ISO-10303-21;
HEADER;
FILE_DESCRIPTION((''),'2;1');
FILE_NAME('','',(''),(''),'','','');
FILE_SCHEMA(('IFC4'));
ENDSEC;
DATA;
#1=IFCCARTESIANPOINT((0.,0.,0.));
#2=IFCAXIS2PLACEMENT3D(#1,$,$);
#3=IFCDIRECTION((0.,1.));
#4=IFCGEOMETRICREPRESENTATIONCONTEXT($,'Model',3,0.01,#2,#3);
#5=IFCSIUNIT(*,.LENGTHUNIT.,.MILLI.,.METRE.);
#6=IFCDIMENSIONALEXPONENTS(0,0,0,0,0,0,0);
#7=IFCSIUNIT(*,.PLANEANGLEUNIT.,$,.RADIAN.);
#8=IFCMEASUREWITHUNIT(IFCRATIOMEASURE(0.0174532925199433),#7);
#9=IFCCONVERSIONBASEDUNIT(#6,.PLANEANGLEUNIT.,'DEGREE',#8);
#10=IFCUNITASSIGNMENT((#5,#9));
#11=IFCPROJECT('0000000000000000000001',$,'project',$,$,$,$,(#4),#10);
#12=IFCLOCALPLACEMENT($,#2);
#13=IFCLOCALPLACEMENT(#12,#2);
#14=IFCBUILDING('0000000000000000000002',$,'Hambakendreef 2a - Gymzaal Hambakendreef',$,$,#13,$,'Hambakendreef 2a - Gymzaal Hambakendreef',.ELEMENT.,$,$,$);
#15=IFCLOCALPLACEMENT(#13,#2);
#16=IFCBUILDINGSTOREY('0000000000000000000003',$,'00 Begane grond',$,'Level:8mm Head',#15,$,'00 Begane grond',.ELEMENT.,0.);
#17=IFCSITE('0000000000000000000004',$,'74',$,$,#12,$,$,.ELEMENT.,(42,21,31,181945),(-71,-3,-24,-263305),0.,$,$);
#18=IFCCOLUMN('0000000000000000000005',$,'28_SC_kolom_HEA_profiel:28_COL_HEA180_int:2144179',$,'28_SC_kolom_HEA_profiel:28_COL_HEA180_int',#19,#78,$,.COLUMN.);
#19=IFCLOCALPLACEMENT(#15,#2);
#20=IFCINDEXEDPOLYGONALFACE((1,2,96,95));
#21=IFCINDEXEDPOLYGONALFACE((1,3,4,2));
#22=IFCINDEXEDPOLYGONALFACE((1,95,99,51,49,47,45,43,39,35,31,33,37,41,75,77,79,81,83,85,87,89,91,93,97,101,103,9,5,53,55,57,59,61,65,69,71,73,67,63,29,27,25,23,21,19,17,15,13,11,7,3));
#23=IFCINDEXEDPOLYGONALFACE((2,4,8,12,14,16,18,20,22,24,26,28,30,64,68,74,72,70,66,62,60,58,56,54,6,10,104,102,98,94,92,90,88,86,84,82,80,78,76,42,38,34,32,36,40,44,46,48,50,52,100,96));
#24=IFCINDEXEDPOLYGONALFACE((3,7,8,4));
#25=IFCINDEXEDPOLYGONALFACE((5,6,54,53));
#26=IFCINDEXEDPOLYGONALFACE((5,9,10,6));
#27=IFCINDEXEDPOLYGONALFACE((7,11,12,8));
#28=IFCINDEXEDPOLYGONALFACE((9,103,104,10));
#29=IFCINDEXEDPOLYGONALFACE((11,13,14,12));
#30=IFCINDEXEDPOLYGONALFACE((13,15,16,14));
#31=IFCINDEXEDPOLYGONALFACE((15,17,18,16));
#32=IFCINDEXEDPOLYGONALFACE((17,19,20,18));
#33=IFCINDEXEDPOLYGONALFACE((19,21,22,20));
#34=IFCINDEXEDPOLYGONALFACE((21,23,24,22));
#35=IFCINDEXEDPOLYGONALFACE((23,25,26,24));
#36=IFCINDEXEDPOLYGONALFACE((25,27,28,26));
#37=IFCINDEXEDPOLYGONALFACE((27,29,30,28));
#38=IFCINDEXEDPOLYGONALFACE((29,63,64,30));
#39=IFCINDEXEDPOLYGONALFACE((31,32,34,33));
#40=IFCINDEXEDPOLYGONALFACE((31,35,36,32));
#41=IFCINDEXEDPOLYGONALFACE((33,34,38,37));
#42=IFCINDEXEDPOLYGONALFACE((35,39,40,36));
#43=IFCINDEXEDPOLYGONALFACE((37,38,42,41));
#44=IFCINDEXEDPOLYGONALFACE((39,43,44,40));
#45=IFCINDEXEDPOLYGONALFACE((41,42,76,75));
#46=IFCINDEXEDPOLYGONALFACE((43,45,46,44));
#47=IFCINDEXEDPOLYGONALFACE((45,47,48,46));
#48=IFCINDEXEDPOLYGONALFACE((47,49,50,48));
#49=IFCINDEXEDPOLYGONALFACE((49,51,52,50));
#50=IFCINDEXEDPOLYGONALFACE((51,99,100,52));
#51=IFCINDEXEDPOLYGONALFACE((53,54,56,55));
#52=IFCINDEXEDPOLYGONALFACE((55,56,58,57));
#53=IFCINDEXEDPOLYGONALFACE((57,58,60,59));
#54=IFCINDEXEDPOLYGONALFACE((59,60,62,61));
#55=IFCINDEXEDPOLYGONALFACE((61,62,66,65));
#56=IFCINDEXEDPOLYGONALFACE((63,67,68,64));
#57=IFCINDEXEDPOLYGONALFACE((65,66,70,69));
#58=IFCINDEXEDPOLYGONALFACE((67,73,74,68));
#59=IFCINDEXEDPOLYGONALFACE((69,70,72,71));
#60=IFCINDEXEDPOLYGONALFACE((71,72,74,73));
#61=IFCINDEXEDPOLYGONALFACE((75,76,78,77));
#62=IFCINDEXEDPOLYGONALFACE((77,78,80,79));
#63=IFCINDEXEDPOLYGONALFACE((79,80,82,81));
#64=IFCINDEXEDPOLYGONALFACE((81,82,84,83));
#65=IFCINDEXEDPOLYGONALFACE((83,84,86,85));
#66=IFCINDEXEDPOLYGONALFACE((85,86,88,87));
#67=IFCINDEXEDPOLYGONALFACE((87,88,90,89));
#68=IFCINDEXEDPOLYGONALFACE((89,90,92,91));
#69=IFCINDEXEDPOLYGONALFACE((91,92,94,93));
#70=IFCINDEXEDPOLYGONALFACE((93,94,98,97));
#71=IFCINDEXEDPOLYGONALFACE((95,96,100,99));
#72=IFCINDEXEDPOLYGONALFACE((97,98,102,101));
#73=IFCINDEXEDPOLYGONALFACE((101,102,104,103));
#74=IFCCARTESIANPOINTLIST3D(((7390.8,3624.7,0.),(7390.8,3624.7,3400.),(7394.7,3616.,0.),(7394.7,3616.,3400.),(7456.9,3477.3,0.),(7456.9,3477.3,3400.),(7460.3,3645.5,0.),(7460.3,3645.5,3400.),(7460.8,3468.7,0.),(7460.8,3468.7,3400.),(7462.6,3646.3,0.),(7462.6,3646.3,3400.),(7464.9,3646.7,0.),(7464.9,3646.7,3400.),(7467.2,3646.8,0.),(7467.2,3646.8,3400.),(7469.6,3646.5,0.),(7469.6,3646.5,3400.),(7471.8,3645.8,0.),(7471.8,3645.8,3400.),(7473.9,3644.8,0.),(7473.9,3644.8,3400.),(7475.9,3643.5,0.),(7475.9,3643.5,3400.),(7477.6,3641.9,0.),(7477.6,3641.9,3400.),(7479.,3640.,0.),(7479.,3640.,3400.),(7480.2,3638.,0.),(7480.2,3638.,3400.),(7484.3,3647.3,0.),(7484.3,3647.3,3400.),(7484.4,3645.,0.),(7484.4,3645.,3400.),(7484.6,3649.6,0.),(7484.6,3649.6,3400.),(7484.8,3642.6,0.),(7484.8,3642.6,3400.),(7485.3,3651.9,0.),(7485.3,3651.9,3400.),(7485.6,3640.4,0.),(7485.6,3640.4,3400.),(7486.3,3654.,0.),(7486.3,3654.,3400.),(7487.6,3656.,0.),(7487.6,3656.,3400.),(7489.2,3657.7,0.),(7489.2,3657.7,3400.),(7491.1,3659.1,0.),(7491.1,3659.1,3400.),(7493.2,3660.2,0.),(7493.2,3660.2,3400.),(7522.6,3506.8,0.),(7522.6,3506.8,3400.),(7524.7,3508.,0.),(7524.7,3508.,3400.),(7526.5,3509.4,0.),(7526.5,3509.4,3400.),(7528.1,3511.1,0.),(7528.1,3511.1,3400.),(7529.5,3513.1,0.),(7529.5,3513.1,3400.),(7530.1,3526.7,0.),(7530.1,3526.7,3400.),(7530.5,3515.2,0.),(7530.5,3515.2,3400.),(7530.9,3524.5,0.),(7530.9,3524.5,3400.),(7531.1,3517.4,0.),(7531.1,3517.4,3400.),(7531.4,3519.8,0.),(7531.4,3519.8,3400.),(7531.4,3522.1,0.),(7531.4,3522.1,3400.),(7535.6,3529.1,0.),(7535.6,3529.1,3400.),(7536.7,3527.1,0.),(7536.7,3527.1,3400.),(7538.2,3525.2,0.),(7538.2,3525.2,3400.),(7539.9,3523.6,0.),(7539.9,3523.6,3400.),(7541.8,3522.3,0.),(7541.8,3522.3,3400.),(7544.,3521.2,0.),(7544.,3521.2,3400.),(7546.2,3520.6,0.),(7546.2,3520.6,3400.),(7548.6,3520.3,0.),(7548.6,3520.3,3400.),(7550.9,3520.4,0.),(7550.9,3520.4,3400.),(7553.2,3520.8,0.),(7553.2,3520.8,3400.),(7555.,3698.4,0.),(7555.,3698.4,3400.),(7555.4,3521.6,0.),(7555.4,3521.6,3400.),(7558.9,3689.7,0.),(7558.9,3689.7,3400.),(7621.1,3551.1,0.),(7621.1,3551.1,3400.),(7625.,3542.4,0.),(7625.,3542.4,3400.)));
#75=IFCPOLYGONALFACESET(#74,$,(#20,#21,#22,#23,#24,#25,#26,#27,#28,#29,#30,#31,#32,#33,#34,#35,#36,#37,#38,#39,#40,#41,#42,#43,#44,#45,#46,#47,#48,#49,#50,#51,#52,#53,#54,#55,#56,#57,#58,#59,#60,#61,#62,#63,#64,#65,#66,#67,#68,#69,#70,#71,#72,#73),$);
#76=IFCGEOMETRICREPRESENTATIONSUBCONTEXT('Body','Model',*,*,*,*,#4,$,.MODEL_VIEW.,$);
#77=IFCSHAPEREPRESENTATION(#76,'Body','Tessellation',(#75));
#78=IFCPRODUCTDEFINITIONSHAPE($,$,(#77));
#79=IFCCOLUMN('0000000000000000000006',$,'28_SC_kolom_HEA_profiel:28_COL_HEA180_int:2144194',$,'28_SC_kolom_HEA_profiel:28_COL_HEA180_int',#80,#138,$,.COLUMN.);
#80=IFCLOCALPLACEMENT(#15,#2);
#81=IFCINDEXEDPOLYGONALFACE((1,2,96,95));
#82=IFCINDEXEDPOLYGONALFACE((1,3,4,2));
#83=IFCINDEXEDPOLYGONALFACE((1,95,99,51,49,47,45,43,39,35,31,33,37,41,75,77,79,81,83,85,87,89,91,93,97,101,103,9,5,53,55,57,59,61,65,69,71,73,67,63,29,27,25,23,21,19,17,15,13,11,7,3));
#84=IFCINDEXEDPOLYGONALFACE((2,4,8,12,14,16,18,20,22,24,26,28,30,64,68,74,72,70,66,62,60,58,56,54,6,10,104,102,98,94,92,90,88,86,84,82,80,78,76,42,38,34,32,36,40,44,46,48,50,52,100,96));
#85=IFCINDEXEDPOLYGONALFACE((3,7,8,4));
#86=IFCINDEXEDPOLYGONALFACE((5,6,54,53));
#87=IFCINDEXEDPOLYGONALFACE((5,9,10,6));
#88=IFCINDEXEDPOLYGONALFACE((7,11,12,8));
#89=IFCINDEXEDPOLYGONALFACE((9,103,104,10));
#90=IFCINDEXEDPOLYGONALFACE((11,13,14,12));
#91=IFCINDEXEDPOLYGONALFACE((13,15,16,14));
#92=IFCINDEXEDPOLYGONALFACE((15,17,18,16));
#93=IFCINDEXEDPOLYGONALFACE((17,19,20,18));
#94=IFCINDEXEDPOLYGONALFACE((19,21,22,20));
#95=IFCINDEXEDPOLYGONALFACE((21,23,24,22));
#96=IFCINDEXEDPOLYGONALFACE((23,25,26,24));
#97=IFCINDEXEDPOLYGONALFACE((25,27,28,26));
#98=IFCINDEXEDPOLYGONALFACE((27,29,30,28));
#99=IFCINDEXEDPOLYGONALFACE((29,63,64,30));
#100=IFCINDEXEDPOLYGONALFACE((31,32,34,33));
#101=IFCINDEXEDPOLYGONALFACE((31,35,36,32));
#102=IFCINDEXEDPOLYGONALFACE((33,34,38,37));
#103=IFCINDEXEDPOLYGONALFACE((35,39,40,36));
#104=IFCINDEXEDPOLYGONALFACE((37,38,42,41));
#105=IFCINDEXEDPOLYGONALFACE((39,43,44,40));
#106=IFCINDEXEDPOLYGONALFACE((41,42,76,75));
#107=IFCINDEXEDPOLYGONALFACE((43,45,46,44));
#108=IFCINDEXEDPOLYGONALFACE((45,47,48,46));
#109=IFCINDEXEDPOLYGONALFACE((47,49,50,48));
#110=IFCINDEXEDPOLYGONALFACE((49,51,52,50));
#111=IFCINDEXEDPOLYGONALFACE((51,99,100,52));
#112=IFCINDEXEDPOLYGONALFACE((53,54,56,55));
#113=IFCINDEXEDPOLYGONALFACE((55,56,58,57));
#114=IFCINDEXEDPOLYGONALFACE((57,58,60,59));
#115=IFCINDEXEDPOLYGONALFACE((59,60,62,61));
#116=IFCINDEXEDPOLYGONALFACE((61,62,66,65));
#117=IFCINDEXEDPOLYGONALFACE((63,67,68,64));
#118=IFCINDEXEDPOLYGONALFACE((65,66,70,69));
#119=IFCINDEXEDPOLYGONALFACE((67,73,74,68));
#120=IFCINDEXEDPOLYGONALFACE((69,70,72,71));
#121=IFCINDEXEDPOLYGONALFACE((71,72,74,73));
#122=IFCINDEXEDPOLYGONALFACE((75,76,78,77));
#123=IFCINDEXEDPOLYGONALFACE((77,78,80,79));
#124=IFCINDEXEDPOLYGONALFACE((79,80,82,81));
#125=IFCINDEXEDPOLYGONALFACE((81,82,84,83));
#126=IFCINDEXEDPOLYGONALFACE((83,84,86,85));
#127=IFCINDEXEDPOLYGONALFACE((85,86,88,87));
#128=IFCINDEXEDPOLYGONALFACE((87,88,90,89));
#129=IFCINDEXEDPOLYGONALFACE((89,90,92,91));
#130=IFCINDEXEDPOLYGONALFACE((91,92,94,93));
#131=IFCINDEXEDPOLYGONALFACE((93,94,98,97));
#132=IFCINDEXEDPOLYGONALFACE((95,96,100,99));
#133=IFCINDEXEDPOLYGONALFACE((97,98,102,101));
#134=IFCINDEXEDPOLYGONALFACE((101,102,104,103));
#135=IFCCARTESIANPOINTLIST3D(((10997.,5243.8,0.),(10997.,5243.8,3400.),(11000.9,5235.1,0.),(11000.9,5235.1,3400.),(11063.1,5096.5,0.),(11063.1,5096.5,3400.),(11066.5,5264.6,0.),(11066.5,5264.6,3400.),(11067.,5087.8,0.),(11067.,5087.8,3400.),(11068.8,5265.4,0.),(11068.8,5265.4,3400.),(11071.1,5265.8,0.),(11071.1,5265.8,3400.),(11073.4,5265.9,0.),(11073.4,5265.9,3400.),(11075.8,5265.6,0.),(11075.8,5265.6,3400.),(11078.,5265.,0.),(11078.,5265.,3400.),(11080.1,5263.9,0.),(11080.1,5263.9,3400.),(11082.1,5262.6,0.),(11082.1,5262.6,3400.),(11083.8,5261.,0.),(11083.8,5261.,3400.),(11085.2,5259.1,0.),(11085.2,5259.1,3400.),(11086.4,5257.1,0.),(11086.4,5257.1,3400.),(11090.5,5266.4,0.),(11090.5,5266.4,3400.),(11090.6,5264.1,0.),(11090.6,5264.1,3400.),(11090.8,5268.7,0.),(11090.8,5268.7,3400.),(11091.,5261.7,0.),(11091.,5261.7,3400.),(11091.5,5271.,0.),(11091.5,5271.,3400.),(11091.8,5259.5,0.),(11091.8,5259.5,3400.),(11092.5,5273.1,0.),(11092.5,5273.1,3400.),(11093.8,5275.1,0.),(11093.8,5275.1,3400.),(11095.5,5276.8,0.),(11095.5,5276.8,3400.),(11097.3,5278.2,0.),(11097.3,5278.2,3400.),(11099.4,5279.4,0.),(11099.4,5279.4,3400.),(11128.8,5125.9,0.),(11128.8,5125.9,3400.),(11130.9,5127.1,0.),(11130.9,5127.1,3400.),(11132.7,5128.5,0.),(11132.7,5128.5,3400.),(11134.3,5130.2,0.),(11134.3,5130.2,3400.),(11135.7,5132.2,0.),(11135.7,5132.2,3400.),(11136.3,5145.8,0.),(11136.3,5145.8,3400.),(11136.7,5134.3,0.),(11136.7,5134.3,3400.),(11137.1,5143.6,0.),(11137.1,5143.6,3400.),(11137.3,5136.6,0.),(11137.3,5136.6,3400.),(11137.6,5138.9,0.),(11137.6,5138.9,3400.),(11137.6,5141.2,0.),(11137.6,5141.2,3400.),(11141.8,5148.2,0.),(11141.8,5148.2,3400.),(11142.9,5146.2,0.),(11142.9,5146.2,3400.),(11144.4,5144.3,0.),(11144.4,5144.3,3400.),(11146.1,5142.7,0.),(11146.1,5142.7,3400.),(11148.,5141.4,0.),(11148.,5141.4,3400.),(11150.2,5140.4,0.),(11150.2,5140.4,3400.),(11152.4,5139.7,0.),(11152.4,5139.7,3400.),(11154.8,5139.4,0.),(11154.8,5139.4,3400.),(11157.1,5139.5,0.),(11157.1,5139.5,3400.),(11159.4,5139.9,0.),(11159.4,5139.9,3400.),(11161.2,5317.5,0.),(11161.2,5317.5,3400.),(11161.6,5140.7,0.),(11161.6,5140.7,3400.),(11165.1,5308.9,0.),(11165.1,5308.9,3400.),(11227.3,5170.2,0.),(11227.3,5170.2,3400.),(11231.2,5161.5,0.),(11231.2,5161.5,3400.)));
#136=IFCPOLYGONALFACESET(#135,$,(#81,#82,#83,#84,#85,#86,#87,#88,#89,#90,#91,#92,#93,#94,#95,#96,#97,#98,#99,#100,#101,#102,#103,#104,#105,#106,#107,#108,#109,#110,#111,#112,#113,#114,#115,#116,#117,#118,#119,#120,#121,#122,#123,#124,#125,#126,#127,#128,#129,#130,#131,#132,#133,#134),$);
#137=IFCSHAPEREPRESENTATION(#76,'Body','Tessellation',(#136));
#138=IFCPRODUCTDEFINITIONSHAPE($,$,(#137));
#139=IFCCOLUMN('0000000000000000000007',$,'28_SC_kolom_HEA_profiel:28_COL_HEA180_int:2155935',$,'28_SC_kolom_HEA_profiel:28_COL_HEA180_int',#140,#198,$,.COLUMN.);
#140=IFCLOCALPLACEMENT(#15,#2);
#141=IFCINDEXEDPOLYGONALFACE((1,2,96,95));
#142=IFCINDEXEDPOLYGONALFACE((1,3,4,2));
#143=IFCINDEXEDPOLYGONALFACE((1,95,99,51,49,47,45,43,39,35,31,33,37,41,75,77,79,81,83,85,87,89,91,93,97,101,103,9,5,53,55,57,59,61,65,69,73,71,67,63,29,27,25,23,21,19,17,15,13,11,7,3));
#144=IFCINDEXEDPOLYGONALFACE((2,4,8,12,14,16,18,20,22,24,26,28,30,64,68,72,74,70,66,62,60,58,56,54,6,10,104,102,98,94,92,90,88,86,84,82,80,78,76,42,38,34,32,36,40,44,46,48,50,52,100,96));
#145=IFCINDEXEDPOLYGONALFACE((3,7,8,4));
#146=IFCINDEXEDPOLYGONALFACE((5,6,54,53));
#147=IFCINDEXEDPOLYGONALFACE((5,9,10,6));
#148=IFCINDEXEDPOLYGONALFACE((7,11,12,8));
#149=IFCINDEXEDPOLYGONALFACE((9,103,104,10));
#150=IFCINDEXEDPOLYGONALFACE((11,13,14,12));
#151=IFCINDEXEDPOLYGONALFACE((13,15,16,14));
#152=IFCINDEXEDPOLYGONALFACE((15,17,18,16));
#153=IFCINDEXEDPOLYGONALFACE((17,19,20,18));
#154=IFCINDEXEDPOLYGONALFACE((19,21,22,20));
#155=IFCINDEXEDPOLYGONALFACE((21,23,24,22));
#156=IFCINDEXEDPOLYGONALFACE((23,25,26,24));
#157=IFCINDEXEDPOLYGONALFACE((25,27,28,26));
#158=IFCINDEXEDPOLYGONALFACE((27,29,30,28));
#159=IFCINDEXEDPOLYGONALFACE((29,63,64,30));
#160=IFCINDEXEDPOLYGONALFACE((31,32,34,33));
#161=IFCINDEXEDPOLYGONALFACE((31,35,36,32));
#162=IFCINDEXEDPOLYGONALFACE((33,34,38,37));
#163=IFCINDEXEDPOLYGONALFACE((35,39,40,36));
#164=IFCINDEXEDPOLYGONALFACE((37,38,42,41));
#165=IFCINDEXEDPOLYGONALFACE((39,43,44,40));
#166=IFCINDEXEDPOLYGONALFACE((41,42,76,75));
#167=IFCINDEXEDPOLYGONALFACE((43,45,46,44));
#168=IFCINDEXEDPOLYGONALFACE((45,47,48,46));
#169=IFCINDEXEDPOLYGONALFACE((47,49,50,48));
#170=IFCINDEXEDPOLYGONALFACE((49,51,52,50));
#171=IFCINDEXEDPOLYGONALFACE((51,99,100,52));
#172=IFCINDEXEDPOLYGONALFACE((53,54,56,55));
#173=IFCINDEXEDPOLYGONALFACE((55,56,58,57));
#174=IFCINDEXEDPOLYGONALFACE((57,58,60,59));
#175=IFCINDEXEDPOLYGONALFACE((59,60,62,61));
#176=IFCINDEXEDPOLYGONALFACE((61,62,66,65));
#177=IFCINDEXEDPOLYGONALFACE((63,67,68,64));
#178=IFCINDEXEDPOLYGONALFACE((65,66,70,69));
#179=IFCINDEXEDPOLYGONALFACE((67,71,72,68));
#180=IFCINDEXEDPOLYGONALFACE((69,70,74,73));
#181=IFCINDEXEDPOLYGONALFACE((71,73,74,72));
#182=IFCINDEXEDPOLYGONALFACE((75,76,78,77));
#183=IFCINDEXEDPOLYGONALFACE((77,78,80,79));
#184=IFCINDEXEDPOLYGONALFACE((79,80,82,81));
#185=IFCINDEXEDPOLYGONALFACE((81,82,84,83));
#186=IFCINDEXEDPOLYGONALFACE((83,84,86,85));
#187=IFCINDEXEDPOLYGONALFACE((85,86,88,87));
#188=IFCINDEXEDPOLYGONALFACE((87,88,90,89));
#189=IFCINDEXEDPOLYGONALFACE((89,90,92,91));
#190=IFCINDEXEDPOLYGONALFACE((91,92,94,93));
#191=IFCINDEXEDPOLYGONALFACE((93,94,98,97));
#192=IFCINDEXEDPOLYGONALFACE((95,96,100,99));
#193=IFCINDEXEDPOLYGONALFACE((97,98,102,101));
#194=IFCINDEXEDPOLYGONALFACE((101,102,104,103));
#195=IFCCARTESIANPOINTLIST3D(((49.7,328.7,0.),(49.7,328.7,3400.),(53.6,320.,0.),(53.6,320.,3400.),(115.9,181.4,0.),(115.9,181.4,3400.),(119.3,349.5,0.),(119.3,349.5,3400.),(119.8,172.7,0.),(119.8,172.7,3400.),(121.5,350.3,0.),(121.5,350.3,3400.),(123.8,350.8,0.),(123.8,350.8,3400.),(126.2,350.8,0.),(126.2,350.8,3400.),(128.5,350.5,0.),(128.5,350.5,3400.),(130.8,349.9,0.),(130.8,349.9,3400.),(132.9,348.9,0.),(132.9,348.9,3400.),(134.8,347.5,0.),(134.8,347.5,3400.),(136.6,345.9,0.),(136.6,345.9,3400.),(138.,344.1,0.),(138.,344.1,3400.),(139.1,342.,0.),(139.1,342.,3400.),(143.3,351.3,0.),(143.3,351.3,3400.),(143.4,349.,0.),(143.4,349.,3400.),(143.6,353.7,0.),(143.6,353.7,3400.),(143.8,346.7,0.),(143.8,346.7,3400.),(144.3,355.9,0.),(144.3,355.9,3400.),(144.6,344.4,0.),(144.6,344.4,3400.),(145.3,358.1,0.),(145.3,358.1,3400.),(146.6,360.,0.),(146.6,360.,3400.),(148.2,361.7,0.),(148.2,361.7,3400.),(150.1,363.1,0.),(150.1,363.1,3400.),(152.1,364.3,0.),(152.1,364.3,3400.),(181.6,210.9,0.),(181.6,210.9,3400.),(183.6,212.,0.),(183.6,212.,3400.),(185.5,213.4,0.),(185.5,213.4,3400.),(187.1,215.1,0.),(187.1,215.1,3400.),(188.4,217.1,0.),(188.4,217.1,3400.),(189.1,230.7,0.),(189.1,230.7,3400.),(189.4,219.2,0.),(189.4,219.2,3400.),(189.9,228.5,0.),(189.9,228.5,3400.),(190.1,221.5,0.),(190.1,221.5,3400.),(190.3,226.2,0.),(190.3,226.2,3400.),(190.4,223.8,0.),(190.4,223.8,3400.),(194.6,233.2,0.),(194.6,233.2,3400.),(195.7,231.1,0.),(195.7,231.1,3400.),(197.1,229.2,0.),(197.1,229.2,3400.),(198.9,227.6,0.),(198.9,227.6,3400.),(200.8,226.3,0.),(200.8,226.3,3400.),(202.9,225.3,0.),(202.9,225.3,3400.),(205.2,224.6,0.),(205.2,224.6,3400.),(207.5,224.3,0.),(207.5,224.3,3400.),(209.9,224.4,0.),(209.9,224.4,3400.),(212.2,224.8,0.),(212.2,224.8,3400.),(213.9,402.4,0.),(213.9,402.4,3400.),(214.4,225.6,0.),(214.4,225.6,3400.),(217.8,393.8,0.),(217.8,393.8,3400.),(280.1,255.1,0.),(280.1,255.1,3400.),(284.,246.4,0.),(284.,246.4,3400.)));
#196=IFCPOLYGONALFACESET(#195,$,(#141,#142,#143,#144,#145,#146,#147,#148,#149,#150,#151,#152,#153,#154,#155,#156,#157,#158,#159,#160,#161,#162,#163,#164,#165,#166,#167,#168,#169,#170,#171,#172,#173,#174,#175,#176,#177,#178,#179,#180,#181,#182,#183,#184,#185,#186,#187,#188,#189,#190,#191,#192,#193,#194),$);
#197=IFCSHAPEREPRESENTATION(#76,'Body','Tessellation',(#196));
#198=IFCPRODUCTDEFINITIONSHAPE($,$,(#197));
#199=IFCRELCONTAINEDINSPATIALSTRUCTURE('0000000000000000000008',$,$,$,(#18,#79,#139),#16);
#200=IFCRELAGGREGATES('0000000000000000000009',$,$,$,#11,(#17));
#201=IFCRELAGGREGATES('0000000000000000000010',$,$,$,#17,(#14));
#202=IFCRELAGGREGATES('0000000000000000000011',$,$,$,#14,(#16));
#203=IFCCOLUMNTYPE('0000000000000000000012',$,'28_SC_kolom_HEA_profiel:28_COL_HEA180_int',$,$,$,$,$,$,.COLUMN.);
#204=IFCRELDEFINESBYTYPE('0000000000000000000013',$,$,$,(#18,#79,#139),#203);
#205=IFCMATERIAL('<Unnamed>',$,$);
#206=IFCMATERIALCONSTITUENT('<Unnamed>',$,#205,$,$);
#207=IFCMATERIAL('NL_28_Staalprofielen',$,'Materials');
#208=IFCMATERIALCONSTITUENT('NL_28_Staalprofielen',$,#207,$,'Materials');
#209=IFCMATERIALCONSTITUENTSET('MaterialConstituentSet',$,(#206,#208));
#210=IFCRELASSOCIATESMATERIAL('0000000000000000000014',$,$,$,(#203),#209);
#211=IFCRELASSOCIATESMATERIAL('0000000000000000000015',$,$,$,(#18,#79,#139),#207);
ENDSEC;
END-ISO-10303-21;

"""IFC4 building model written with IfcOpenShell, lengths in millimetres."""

from ifc_helpers import new_model, entity, si_unit, converted_unit, direction, frame, origin, place, context, subcontext, project, spatial, indexed_curve, outline, extrude, source, transform, mapped, material, constituent, constituent_set, type_object, type_shapes, element, save


model = new_model("IFC4")

# Units and contexts
model_context = context("Model", 3, precision=0.01, world=origin(), true_north=direction((0.0, 1.0)))
body_context = subcontext(model_context, "Body", "Model", "MODEL_VIEW")
ifc_project = project(units=[si_unit("LENGTHUNIT", "METRE", prefix="MILLI"), converted_unit("PLANEANGLEUNIT", "DEGREE", entity("IfcRatioMeasure", 0.0174532925199433), si_unit("PLANEANGLEUNIT", "RADIAN"), dimensions=[0, 0, 0, 0, 0, 0, 0])], contexts=[model_context])

# Site, building, storey
site_placement = place(None, origin())
site = spatial("IfcSite", under=ifc_project, at=site_placement, Name="74", CompositionType="ELEMENT", RefLatitude=(42, 21, 31, 181945), RefLongitude=(-71, -3, -24, -263305), RefElevation=0.0)
building_placement = place(site_placement, origin())
building = spatial("IfcBuilding", under=site, at=building_placement, Name="Hambakendreef 2a - Gymzaal Hambakendreef", LongName="Hambakendreef 2a - Gymzaal Hambakendreef", CompositionType="ELEMENT")
storey_placement = place(building_placement, origin())
storey = spatial("IfcBuildingStorey", under=building, at=storey_placement, Name="00 Begane grond", ObjectType="Level:8mm Head", LongName="00 Begane grond", CompositionType="ELEMENT", Elevation=0.0)

# Columns
ifc_material_1 = material(Name="NL_28_Staalprofielen", Category="Materials")
ifc_material_2 = material(Name="<Unnamed>")
ifc_constituent_1 = constituent(ifc_material_2, Name="<Unnamed>")
ifc_constituent_2 = constituent(ifc_material_1, Name="NL_28_Staalprofielen", Category="Materials")
ifc_constituent_set_1 = constituent_set(constituents=[ifc_constituent_1, ifc_constituent_2], Name="MaterialConstituentSet")
column_type_1 = type_object("IfcColumnType", Name="28_SC_kolom_HEA_profiel:28_COL_HEA180_int", PredefinedType="COLUMN", material=ifc_constituent_set_1)
shared_shape_1 = source(origin(), body_context, "Body", "SweptSolid", [
    extrude(outline(indexed_curve([(76.0, -90.0), (85.5, -90.0), (85.5, 90.0), (76.0, 90.0), (76.0, 18.0), (75.8, 15.7), (75.3, 13.4), (74.4, 11.2), (73.1, 9.2), (71.6, 7.4), (69.8, 5.9), (67.8, 4.6), (65.6, 3.7), (63.3, 3.2), (61.0, 3.0), (-61.0, 3.0), (-63.3, 3.2), (-65.6, 3.7), (-67.8, 4.6), (-69.8, 5.9), (-71.6, 7.4), (-73.1, 9.2), (-74.4, 11.2), (-75.3, 13.4), (-75.8, 15.7), (-76.0, 18.0), (-76.0, 90.0), (-85.5, 90.0), (-85.5, -90.0), (-76.0, -90.0), (-76.0, -18.0), (-75.8, -15.7), (-75.3, -13.4), (-74.4, -11.2), (-73.1, -9.2), (-71.6, -7.4), (-69.8, -5.9), (-67.8, -4.6), (-65.6, -3.7), (-63.3, -3.2), (-61.0, -3.0), (61.0, -3.0), (63.3, -3.2), (65.6, -3.7), (67.8, -4.6), (69.8, -5.9), (71.6, -7.4), (73.1, -9.2), (74.4, -11.2), (75.3, -13.4), (75.8, -15.7), (76.0, -18.0), (76.0, -90.0)], self_intersect=False)), frame((0.0, 0.0, 0.0), z_axis=(0.0, 0.0, 1.0), x_axis=(0.0, -1.0, 0.0)), (0.0, 0.0, 1.0), 3400.0),
])
type_shapes(column_type_1, [shared_shape_1])
for number, where, z_axis, x_axis, name in (
    (1, (7507.9, 3583.5, 0.0), (0.0, 0.0, 1.0), (0.91227, 0.40959, 0.0), "28_SC_kolom_HEA_profiel:28_COL_HEA180_int:2144179"),
    (2, (11114.1, 5202.7, 0.0), (0.0, 0.0, 1.0), (0.91227, 0.40959, 0.0), "28_SC_kolom_HEA_profiel:28_COL_HEA180_int:2144194"),
    (3, (166.9, 287.6, 0.0), (0.0, 0.0, 1.0), (0.91227, 0.40959, 0.0), "28_SC_kolom_HEA_profiel:28_COL_HEA180_int:2155935"),
):
    element("IfcColumn", number, at=place(storey_placement, frame(where, z_axis=z_axis, x_axis=x_axis)), inside=storey, type_object=column_type_1, material=ifc_material_1, Name=name, ObjectType="28_SC_kolom_HEA_profiel:28_COL_HEA180_int", PredefinedType="COLUMN", context=body_context, shape_type="MappedRepresentation", body=[
        mapped(shared_shape_1, transform((0.0, 0.0, 0.0), scale=1.0)),
    ])

save(model, "model.ifc")
